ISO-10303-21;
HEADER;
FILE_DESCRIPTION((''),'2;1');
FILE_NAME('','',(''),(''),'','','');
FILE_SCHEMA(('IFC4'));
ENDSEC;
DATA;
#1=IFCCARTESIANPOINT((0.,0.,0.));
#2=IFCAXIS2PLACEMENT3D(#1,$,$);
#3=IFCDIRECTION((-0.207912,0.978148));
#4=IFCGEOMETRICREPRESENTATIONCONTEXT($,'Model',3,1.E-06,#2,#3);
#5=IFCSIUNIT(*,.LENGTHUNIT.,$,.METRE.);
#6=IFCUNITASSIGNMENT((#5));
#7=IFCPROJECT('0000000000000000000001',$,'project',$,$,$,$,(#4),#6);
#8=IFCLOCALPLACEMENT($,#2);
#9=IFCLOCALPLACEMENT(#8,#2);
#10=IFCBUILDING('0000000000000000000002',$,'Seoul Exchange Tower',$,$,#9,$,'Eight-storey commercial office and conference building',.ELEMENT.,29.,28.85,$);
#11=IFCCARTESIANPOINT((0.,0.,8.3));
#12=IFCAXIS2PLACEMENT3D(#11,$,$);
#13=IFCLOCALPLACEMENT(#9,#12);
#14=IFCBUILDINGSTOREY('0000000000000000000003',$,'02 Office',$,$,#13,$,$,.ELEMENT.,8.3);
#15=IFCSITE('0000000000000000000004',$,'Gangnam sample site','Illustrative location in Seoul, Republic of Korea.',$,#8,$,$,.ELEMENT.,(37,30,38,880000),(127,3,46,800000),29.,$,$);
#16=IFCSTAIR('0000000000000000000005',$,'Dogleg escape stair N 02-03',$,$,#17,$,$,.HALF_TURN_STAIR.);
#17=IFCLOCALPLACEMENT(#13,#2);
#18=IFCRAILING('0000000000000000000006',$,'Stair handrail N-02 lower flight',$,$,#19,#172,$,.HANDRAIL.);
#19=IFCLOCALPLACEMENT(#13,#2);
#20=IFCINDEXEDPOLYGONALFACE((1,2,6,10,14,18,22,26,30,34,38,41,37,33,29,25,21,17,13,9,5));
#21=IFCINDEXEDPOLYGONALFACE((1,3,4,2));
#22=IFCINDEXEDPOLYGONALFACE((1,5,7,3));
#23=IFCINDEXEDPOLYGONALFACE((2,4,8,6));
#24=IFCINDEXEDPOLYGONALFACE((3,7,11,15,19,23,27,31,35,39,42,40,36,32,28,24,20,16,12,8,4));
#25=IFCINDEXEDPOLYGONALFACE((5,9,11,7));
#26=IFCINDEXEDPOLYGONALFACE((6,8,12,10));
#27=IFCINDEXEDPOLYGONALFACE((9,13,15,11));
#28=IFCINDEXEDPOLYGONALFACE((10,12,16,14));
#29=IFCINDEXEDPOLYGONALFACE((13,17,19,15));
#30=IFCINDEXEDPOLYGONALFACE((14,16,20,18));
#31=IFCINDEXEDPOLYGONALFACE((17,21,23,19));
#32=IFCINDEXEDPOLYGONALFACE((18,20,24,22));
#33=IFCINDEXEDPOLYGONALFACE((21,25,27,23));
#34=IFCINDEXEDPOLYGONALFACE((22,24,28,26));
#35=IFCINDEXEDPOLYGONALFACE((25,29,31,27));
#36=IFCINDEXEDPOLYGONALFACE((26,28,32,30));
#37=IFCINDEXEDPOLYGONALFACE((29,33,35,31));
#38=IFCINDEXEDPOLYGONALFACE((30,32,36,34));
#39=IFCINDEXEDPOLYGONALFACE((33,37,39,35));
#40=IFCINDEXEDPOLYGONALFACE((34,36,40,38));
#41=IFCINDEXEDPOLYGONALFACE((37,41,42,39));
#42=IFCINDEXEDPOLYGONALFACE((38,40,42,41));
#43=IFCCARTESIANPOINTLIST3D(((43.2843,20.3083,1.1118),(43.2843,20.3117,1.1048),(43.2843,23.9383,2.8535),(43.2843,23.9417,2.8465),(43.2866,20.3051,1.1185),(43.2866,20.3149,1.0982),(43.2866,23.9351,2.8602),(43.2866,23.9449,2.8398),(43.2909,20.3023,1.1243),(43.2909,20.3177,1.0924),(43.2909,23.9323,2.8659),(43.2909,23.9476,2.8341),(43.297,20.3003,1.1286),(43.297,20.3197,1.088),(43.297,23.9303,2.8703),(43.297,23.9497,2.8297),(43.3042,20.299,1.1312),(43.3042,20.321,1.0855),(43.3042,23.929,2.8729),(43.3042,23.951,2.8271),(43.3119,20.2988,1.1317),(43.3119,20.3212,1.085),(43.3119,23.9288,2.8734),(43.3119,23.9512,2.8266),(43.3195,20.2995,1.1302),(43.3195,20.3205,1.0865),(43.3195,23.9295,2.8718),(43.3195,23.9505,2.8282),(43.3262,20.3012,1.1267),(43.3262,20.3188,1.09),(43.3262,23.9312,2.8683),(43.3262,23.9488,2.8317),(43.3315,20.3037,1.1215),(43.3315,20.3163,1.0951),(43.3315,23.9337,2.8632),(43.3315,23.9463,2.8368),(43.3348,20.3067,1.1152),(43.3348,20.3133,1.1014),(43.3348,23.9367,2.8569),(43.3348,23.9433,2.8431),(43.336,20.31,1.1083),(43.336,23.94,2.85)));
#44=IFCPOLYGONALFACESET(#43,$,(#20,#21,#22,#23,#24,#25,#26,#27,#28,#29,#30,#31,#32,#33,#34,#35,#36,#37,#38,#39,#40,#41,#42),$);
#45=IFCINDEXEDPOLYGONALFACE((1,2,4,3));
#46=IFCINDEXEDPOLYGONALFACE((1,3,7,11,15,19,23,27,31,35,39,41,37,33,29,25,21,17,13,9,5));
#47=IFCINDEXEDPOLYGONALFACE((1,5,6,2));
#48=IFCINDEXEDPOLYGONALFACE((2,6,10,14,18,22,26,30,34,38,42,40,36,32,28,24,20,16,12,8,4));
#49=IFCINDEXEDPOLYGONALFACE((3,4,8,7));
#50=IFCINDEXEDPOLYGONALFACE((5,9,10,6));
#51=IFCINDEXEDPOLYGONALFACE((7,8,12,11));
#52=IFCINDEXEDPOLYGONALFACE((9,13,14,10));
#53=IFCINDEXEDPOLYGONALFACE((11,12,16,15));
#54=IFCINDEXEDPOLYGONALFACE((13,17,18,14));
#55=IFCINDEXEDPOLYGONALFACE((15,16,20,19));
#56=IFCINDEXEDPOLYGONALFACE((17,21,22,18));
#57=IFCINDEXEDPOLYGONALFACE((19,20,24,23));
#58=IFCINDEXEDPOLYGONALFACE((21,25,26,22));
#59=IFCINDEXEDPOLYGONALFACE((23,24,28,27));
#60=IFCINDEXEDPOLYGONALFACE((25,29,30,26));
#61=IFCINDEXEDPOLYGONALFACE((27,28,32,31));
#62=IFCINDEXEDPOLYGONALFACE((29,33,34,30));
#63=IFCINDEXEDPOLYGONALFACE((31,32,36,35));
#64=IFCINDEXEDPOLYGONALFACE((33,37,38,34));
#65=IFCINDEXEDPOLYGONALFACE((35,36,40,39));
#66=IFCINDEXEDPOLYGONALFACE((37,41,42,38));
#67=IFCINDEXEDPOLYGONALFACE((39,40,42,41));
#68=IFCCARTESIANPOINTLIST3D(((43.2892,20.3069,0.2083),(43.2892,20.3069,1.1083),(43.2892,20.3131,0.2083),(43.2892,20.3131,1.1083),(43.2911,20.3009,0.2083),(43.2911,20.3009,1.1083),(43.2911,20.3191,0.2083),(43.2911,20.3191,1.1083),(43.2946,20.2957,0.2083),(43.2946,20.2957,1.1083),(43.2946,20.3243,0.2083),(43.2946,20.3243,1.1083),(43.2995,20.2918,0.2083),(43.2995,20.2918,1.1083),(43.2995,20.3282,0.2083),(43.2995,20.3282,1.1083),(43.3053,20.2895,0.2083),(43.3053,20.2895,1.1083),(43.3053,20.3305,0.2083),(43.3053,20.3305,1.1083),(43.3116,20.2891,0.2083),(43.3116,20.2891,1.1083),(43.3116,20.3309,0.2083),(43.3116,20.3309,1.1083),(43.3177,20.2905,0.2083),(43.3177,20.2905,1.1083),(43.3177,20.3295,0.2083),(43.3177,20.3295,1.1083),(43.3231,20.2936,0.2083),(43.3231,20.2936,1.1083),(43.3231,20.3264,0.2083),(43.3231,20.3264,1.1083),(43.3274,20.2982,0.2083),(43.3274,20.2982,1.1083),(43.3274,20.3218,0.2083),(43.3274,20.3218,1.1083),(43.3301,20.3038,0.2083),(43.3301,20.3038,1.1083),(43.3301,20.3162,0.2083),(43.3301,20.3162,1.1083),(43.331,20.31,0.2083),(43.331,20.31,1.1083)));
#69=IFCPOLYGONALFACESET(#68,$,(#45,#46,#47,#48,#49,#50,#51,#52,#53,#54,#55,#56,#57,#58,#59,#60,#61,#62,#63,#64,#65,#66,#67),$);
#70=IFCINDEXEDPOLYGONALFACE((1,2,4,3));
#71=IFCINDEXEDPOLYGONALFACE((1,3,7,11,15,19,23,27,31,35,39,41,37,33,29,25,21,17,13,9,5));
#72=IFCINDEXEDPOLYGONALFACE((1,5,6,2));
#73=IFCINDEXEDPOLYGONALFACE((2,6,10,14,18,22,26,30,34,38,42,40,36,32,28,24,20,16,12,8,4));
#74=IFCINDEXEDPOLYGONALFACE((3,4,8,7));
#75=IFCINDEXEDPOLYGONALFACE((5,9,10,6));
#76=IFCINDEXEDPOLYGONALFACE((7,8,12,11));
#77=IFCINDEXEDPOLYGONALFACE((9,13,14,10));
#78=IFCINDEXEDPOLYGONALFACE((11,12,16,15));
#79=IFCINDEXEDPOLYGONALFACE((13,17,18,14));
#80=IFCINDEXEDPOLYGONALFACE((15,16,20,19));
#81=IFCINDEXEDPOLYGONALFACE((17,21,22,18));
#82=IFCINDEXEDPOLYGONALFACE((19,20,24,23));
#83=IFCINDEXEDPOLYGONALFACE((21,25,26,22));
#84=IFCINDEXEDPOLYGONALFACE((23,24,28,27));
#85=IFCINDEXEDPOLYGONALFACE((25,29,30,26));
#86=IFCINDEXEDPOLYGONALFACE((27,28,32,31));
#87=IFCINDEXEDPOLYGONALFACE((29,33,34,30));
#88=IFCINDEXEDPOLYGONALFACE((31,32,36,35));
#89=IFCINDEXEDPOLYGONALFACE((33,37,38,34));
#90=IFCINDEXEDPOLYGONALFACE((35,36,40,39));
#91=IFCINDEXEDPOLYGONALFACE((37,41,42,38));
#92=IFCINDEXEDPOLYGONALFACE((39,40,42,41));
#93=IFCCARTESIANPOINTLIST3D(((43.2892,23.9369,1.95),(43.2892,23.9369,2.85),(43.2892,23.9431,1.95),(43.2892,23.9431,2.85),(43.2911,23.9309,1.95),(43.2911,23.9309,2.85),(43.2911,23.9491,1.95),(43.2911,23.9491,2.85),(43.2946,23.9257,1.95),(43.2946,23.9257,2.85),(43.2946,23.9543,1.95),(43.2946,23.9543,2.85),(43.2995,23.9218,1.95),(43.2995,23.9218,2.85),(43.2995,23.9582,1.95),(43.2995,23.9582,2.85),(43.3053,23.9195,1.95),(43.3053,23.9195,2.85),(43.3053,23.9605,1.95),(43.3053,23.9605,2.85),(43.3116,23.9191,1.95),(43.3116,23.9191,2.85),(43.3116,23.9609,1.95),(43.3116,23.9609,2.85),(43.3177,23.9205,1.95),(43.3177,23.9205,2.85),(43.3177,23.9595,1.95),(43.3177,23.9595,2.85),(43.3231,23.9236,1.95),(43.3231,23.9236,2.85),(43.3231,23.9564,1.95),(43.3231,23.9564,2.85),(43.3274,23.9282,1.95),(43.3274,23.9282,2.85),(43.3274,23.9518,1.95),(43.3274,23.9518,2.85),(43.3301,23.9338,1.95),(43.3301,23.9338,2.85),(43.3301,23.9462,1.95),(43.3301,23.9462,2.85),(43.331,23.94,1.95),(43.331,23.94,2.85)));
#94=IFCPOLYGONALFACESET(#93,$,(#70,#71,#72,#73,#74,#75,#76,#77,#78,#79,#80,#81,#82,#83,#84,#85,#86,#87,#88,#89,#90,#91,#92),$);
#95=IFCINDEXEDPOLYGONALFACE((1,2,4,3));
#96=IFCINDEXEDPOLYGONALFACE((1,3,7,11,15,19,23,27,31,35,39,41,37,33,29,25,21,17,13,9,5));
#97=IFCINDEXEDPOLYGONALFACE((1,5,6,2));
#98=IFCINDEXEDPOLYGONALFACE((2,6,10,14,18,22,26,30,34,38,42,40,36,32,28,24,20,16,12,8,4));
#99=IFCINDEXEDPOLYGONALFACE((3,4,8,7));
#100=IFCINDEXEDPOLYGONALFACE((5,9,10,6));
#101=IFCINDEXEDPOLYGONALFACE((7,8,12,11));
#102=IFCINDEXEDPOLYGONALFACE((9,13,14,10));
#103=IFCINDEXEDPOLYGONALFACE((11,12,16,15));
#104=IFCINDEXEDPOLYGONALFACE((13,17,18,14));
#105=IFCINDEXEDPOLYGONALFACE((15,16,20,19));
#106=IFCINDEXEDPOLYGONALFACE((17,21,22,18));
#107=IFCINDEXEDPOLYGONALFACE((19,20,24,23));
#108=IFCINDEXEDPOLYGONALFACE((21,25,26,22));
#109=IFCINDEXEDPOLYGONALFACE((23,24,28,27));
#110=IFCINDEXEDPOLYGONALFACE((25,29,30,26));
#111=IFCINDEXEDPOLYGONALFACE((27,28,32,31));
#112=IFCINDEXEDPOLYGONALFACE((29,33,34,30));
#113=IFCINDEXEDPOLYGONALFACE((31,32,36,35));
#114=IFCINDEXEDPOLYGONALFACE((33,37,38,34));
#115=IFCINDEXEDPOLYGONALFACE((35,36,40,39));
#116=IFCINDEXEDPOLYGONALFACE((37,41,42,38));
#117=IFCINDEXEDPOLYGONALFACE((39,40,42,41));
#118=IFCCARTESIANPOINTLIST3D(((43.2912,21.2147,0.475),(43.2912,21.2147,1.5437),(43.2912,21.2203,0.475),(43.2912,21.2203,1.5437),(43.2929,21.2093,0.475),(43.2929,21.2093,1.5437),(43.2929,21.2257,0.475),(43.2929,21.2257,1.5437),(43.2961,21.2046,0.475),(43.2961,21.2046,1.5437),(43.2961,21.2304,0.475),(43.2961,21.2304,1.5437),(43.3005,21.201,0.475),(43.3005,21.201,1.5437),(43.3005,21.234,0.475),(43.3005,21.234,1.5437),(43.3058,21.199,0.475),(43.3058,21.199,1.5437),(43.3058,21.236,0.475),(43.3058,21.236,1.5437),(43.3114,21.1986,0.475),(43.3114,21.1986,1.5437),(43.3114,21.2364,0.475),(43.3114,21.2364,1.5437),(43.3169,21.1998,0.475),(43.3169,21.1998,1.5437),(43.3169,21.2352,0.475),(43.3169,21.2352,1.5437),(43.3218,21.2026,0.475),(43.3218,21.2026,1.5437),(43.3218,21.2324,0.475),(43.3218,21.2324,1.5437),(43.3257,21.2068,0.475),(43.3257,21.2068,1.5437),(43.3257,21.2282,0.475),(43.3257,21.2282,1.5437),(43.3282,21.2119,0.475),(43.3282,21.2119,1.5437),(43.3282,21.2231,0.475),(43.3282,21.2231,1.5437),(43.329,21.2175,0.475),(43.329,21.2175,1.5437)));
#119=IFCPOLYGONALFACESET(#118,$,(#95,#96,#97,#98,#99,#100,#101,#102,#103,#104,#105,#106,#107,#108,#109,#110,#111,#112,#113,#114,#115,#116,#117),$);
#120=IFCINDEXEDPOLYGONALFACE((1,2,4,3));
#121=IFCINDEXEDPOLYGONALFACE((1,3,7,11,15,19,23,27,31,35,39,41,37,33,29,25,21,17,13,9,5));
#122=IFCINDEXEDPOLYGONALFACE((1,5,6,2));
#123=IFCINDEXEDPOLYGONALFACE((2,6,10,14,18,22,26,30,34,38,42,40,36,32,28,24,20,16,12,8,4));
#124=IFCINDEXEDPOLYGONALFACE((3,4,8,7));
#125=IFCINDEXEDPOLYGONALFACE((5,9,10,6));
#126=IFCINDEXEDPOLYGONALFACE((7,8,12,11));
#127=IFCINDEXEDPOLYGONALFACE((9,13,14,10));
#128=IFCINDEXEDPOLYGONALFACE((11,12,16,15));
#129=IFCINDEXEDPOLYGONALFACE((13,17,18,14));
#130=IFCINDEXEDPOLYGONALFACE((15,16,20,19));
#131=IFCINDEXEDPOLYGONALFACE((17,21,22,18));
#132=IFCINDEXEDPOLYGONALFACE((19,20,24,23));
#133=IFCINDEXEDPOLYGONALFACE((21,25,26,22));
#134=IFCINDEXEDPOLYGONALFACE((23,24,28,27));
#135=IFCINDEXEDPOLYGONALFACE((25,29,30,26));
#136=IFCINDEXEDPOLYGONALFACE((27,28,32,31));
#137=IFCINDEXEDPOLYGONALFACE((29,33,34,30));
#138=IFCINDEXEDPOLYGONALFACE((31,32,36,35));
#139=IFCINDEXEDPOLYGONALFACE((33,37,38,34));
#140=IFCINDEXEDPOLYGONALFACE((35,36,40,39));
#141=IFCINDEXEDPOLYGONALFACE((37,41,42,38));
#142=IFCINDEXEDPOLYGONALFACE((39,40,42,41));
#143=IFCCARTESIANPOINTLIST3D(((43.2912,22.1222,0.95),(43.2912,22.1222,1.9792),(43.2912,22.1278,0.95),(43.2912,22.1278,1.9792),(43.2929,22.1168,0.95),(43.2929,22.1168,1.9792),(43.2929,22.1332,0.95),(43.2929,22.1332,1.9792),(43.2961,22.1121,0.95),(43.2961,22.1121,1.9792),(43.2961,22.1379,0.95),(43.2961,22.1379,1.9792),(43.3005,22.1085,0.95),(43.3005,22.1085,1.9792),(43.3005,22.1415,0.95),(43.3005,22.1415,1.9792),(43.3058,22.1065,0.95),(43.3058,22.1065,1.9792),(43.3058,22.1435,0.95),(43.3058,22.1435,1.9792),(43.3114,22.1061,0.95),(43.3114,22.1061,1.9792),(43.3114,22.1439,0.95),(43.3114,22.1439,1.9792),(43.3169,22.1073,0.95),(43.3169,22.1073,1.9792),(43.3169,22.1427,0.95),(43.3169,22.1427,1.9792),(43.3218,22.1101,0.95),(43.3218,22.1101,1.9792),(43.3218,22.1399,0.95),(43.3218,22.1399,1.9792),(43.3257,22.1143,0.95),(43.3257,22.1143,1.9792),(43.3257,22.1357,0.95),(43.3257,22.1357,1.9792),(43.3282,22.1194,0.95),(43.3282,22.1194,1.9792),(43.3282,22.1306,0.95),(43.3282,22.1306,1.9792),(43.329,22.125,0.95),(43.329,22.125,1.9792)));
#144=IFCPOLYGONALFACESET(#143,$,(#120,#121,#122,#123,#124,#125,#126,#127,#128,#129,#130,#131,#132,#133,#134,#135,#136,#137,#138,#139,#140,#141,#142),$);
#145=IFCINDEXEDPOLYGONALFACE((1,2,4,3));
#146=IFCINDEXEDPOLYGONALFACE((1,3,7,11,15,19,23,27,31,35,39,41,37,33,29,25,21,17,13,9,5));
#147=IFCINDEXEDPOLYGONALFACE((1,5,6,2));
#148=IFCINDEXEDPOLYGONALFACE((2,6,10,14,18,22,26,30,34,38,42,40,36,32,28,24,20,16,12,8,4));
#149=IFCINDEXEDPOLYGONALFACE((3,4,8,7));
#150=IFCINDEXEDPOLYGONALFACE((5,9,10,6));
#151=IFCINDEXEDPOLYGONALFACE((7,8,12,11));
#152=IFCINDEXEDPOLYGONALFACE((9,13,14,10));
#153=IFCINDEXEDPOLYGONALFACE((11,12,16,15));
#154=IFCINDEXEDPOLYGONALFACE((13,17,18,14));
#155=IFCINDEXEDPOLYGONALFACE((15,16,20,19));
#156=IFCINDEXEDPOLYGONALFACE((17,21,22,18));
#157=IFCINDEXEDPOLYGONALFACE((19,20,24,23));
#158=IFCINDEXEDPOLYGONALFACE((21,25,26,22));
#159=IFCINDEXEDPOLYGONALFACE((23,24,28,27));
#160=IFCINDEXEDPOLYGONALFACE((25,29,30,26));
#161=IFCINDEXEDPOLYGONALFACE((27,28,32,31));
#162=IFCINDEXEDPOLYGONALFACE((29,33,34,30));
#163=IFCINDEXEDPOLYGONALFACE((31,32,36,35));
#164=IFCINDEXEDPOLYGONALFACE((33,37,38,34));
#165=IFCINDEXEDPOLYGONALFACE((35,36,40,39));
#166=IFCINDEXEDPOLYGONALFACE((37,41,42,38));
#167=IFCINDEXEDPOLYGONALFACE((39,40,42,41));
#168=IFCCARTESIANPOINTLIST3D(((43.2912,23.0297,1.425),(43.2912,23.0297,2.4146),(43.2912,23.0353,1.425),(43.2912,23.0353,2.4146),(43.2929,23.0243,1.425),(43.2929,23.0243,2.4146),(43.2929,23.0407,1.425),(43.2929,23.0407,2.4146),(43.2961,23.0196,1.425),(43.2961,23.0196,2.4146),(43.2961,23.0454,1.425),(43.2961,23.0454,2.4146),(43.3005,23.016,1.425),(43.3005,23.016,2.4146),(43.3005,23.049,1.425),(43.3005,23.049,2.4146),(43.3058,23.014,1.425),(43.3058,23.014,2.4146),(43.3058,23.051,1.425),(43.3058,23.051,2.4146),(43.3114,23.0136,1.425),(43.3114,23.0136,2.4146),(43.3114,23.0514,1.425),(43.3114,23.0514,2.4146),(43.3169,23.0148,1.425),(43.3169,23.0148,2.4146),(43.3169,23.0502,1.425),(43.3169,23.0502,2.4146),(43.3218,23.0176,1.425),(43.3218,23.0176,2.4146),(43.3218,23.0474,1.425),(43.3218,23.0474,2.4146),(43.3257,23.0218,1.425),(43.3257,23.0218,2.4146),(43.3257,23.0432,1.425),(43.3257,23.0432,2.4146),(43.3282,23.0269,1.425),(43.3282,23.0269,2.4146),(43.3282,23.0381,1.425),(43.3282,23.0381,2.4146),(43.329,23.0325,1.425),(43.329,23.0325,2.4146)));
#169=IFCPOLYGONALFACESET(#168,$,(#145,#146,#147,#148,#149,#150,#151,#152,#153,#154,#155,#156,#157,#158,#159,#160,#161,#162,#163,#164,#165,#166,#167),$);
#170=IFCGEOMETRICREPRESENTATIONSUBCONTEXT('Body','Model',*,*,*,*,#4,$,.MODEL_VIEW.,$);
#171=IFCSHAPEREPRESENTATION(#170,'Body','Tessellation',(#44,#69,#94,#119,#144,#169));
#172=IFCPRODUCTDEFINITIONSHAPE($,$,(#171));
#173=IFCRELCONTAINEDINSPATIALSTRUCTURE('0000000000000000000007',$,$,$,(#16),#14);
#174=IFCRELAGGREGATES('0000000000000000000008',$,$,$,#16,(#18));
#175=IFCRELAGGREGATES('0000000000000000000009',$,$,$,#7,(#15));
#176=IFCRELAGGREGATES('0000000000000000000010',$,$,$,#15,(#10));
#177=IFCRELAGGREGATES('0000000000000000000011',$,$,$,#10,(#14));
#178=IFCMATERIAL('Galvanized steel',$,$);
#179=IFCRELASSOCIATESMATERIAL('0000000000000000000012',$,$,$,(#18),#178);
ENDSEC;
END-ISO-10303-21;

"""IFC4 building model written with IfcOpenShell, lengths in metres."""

from ifc_helpers import new_model, si_unit, direction, frame, origin, place, context, subcontext, project, spatial, circle, extrude, material, element, aggregate, save


model = new_model("IFC4")

# Units and contexts
model_context = context("Model", 3, precision=1e-06, world=origin(), true_north=direction((-0.207912, 0.978148)))
body_context = subcontext(model_context, "Body", "Model", "MODEL_VIEW")
ifc_project = project(units=[si_unit("LENGTHUNIT", "METRE")], contexts=[model_context])

# Site, building, storey
site_placement = place(None, origin())
site = spatial("IfcSite", under=ifc_project, at=site_placement, Name="Gangnam sample site", Description="Illustrative location in Seoul, Republic of Korea.", CompositionType="ELEMENT", RefLatitude=(37, 30, 38, 880000), RefLongitude=(127, 3, 46, 800000), RefElevation=29.0)
building_placement = place(site_placement, origin())
building = spatial("IfcBuilding", under=site, at=building_placement, Name="Seoul Exchange Tower", LongName="Eight-storey commercial office and conference building", CompositionType="ELEMENT", ElevationOfRefHeight=29.0, ElevationOfTerrain=28.85)
storey_placement = place(building_placement, frame((0.0, 0.0, 8.3)))
storey = spatial("IfcBuildingStorey", under=building, at=storey_placement, Name="02 Office", CompositionType="ELEMENT", Elevation=8.3)

# Shared definitions
placement_1 = place(storey_placement, origin())

# Stair
stair_1 = element("IfcStair", 1, at=placement_1, inside=storey, Name="Dogleg escape stair N 02-03", PredefinedType="HALF_TURN_STAIR")
placement_2 = place(placement_1, origin())

# Railing
ifc_material_1 = material(Name="Galvanized steel")
railing_1 = element("IfcRailing", 2, at=placement_2, material=ifc_material_1, Name="Stair handrail N-02 lower flight", PredefinedType="HANDRAIL", context=body_context, shape_type="SweptSolid", body=[
    extrude(circle(Radius=0.026), frame((43.31, 20.31, 1.1083), z_axis=(0.0, 0.901594, 0.432583), x_axis=(1.0, 0.0, 0.0)), (0.0, 0.0, 1.0), 4.0262),
    extrude(circle(Radius=0.021), frame((43.31, 20.31, 0.2083), z_axis=(0.0, 0.0, 1.0), x_axis=(1.0, 0.0, 0.0)), (0.0, 0.0, 1.0), 0.9),
    extrude(circle(Radius=0.021), frame((43.31, 23.94, 1.95), z_axis=(0.0, 0.0, 1.0), x_axis=(1.0, 0.0, 0.0)), (0.0, 0.0, 1.0), 0.9),
    extrude(circle(Radius=0.019), frame((43.31, 21.2175, 0.475), z_axis=(0.0, 0.0, 1.0), x_axis=(1.0, 0.0, 0.0)), (0.0, 0.0, 1.0), 1.0688),
    extrude(circle(Radius=0.019), frame((43.31, 22.125, 0.95), z_axis=(0.0, 0.0, 1.0), x_axis=(1.0, 0.0, 0.0)), (0.0, 0.0, 1.0), 1.0292),
    extrude(circle(Radius=0.019), frame((43.31, 23.0325, 1.425), z_axis=(0.0, 0.0, 1.0), x_axis=(1.0, 0.0, 0.0)), (0.0, 0.0, 1.0), 0.9896),
])
aggregate(stair_1, [railing_1])

save(model, "model.ifc")
